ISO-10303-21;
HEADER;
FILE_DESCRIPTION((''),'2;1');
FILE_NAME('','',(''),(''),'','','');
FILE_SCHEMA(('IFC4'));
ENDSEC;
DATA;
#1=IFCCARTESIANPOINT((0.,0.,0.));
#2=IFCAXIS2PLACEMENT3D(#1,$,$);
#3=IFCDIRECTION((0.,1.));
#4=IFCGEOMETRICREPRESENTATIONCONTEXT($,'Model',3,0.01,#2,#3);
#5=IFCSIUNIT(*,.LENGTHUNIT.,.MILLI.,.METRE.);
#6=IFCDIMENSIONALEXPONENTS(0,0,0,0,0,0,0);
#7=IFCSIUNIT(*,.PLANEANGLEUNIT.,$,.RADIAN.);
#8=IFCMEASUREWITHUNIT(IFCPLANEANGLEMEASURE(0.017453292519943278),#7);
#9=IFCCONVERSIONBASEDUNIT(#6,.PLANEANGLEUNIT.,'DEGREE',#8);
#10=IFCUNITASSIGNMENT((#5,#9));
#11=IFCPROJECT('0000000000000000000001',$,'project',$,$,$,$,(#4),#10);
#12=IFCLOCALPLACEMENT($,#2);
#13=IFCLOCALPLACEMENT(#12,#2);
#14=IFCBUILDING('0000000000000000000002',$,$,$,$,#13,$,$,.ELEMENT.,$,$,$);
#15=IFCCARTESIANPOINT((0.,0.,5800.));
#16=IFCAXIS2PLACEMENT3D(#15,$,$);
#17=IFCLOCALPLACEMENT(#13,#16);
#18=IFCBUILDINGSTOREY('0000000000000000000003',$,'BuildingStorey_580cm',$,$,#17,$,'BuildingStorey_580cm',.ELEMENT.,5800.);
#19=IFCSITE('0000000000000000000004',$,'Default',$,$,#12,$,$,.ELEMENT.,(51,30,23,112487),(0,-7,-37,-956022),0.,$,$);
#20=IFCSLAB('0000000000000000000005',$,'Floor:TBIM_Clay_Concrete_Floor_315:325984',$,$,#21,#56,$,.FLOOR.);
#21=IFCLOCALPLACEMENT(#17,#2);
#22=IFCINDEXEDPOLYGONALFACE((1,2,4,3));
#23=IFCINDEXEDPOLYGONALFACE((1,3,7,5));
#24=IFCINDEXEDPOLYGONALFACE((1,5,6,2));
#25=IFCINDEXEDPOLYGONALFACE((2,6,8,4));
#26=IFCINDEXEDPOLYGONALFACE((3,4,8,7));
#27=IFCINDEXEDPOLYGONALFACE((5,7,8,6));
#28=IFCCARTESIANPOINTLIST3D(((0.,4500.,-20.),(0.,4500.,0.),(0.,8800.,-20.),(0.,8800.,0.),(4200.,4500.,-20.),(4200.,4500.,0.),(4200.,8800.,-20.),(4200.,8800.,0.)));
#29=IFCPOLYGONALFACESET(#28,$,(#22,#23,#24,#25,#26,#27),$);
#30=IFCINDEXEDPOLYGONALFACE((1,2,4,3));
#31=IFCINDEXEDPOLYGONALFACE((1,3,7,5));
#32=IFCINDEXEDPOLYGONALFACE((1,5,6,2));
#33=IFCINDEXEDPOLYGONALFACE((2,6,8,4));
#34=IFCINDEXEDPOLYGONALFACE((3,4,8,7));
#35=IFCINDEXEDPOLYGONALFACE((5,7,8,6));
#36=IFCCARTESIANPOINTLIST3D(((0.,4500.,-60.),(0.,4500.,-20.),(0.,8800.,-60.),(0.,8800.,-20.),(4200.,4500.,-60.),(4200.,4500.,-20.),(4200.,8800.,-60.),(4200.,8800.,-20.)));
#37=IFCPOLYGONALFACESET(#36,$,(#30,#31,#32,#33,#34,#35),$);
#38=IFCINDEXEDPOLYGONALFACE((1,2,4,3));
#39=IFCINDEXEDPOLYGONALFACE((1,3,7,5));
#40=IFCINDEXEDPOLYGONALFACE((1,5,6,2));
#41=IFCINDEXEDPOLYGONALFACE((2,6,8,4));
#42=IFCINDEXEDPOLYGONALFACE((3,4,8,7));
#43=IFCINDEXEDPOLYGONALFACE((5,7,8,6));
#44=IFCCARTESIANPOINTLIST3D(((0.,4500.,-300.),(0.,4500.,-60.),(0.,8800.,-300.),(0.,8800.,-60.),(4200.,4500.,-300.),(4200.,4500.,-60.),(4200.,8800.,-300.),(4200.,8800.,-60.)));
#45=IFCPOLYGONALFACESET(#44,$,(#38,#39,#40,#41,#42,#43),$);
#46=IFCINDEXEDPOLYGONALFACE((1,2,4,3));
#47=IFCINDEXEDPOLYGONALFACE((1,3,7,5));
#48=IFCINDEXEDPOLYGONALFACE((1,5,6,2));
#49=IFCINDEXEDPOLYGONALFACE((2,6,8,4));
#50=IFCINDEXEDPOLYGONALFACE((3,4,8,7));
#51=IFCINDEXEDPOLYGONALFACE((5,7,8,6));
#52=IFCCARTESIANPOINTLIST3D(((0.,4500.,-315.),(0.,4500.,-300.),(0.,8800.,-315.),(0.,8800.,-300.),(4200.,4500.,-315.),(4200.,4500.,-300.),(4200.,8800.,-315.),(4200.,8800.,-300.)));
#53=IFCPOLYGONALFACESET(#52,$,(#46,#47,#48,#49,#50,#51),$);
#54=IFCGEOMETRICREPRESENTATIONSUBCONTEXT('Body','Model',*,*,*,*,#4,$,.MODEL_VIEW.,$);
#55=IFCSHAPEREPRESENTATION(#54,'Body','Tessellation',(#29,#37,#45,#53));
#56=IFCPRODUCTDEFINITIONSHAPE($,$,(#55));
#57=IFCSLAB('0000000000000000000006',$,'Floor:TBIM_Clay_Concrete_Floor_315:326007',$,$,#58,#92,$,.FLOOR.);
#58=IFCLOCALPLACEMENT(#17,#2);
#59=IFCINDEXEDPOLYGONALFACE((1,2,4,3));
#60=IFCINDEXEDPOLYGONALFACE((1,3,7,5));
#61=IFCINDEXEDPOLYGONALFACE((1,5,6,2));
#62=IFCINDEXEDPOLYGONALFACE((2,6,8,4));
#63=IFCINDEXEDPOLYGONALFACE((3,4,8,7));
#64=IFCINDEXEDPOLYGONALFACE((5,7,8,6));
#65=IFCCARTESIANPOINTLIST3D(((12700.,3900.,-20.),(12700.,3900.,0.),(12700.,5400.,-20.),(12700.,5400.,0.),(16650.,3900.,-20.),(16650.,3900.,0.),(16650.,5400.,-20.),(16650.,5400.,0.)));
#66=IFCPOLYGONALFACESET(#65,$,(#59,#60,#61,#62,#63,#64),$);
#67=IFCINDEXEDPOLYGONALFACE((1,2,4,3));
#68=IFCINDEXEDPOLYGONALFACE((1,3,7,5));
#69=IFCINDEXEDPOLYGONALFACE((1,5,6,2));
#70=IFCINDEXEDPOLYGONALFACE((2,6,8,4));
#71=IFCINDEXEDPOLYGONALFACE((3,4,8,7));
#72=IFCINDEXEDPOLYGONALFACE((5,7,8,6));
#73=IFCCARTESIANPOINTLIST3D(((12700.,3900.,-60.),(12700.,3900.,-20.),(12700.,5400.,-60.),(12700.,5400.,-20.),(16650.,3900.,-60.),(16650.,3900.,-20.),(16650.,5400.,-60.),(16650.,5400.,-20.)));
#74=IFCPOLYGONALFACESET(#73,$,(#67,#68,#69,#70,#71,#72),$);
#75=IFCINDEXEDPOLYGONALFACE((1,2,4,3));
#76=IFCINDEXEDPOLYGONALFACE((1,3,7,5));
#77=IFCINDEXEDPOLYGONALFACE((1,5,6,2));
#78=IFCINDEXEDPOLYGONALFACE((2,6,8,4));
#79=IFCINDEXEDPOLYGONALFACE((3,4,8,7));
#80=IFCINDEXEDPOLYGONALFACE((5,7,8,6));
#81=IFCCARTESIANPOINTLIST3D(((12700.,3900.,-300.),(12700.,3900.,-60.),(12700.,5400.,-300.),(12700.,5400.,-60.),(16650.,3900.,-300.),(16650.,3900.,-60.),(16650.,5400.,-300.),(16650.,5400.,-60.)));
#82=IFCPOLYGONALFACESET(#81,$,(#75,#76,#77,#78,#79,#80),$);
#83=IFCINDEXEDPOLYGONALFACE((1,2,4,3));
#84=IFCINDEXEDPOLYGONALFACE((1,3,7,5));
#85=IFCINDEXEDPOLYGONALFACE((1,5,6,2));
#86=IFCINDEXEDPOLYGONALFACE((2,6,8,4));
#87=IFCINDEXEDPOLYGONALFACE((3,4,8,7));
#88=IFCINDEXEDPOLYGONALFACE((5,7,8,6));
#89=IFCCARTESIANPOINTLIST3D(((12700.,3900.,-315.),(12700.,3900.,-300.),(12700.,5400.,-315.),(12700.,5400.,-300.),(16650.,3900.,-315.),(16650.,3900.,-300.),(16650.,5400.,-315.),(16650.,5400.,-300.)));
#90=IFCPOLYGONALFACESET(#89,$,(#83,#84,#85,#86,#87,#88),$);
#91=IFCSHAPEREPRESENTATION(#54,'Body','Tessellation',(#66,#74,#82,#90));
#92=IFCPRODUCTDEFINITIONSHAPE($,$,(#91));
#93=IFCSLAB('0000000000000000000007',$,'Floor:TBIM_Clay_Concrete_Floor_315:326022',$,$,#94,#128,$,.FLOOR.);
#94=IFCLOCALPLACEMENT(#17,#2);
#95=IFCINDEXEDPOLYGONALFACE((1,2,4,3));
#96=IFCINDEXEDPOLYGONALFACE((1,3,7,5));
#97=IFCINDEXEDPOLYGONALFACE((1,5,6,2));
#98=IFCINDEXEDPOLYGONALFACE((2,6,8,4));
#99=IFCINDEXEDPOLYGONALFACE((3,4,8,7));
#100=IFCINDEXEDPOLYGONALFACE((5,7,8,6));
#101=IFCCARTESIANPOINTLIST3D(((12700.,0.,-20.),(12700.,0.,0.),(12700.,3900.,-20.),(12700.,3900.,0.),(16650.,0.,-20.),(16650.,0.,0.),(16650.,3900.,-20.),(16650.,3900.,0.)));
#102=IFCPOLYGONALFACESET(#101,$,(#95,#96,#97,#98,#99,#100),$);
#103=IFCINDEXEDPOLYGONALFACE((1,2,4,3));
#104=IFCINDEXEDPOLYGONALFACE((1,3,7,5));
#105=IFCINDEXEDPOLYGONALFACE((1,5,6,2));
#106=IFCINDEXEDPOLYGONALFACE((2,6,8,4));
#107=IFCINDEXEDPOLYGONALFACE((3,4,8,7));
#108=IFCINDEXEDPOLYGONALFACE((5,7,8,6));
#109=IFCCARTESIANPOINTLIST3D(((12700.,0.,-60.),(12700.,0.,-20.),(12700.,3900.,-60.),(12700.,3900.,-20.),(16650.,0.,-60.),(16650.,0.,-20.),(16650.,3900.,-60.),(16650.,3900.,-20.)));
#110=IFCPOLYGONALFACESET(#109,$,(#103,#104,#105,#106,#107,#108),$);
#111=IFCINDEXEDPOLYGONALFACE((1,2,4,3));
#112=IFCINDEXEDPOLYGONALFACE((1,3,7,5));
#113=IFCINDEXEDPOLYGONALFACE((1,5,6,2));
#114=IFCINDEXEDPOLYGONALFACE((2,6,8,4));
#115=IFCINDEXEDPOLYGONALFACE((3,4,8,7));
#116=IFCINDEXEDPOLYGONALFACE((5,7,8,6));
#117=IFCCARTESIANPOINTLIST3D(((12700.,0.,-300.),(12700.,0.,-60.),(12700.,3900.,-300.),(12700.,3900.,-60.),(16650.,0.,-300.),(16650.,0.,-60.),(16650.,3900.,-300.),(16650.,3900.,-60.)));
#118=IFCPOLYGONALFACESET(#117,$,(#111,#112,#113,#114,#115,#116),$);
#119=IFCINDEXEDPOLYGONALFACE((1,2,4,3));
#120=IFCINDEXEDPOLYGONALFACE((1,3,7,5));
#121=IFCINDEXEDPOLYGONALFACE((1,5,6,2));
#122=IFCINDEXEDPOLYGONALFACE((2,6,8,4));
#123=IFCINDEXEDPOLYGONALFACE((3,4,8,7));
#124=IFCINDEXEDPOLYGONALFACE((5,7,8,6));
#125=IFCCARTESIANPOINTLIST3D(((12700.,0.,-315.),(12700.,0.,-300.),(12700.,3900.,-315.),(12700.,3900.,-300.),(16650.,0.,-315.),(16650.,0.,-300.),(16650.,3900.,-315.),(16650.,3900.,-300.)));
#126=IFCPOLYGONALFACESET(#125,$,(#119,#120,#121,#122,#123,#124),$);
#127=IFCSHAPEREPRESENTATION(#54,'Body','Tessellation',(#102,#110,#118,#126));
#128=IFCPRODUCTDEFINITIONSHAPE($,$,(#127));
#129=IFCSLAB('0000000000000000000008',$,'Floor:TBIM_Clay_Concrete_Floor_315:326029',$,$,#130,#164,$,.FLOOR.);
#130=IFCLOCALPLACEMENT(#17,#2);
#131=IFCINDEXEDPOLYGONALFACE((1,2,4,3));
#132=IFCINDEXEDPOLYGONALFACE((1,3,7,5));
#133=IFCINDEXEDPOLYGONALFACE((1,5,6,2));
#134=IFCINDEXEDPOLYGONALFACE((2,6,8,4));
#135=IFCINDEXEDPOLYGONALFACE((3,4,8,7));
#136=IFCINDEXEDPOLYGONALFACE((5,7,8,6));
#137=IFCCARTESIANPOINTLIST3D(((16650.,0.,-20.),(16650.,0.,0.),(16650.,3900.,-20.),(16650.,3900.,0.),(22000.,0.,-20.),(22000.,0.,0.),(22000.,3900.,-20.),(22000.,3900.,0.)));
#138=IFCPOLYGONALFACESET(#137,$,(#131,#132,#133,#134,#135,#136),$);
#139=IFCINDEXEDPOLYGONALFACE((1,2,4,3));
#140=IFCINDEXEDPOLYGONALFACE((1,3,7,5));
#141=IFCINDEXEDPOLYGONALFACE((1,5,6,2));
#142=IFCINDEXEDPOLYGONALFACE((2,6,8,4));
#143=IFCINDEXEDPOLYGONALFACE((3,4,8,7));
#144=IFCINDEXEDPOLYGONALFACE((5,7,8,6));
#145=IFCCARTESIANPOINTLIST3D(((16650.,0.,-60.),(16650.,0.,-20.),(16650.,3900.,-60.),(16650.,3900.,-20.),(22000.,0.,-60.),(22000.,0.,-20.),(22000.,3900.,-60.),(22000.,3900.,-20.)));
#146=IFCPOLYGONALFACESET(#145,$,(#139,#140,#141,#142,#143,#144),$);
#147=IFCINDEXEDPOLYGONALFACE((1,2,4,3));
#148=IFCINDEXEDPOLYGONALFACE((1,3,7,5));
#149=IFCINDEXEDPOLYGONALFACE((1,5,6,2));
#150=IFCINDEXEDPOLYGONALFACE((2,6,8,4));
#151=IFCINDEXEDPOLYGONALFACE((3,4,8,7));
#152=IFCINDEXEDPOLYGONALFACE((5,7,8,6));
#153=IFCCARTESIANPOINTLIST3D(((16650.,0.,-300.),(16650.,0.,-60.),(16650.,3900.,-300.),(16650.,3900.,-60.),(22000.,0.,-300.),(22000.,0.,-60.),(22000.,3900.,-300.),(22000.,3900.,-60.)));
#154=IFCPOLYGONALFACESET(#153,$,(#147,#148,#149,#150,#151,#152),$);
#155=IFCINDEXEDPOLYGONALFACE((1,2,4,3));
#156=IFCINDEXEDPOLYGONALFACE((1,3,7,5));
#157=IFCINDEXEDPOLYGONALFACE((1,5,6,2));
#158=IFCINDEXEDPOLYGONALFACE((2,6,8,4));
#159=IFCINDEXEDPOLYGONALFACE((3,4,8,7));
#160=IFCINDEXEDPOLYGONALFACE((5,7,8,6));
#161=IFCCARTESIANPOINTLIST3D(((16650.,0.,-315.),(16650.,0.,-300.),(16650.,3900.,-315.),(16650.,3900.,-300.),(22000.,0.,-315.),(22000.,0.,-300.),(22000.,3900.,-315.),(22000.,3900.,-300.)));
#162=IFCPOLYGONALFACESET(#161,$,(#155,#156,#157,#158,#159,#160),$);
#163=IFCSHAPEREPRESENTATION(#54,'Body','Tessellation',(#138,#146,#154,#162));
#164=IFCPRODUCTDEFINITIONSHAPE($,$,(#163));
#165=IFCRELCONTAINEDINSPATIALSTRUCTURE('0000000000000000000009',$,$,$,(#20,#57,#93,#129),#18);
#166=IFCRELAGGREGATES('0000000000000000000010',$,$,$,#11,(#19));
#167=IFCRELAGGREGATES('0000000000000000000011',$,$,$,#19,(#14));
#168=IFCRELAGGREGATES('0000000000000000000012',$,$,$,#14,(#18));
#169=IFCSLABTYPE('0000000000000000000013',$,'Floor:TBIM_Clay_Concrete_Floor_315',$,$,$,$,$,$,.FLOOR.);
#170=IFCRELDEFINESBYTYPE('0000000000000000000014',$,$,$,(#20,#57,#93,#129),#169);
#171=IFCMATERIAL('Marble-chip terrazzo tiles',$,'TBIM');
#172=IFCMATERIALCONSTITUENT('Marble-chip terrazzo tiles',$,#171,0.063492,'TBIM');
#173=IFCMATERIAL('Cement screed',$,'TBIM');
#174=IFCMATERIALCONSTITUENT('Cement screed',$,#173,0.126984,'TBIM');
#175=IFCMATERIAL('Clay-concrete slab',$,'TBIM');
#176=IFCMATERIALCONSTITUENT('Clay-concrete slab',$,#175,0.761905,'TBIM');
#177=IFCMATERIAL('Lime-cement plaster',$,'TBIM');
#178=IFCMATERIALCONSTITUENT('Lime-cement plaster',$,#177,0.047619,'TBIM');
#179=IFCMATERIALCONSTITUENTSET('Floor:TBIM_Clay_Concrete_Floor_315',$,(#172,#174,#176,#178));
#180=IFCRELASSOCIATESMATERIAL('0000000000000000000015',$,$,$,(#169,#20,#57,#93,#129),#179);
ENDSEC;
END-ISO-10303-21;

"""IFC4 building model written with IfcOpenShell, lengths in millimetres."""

from ifc_helpers import new_model, entity, si_unit, converted_unit, direction, frame, origin, place, context, subcontext, project, spatial, indexed_curve, outline, extrude, material, constituent, constituent_set, type_object, element, save


model = new_model("IFC4")

# Units and contexts
model_context = context("Model", 3, precision=0.01, world=origin(), true_north=direction((0.0, 1.0)))
body_context = subcontext(model_context, "Body", "Model", "MODEL_VIEW")
ifc_project = project(units=[si_unit("LENGTHUNIT", "METRE", prefix="MILLI"), converted_unit("PLANEANGLEUNIT", "DEGREE", entity("IfcPlaneAngleMeasure", 0.017453292519943278), si_unit("PLANEANGLEUNIT", "RADIAN"), dimensions=[0, 0, 0, 0, 0, 0, 0])], contexts=[model_context])

# Site, building, storey
site_placement = place(None, origin())
site = spatial("IfcSite", under=ifc_project, at=site_placement, Name="Default", CompositionType="ELEMENT", RefLatitude=(51, 30, 23, 112487), RefLongitude=(0, -7, -37, -956022), RefElevation=0.0)
building_placement = place(site_placement, origin())
building = spatial("IfcBuilding", under=site, at=building_placement, CompositionType="ELEMENT")
storey_placement = place(building_placement, frame((0.0, 0.0, 5800.0)))
storey = spatial("IfcBuildingStorey", under=building, at=storey_placement, Name="BuildingStorey_580cm", LongName="BuildingStorey_580cm", CompositionType="ELEMENT", Elevation=5800.0)

# Slabs
ifc_material_1 = material(Name="Marble-chip terrazzo tiles", Category="TBIM")
ifc_constituent_1 = constituent(ifc_material_1, Name="Marble-chip terrazzo tiles", Category="TBIM", fraction=0.063492)
ifc_material_2 = material(Name="Cement screed", Category="TBIM")
ifc_constituent_2 = constituent(ifc_material_2, Name="Cement screed", Category="TBIM", fraction=0.126984)
ifc_material_3 = material(Name="Clay-concrete slab", Category="TBIM")
ifc_constituent_3 = constituent(ifc_material_3, Name="Clay-concrete slab", Category="TBIM", fraction=0.761905)
ifc_material_4 = material(Name="Lime-cement plaster", Category="TBIM")
ifc_constituent_4 = constituent(ifc_material_4, Name="Lime-cement plaster", Category="TBIM", fraction=0.047619)
ifc_constituent_set_1 = constituent_set(constituents=[ifc_constituent_1, ifc_constituent_2, ifc_constituent_3, ifc_constituent_4], Name="Floor:TBIM_Clay_Concrete_Floor_315")
slab_type = type_object("IfcSlabType", Name="Floor:TBIM_Clay_Concrete_Floor_315", PredefinedType="FLOOR", material=ifc_constituent_set_1)
slab_1_placement = place(storey_placement, origin())
element("IfcSlab", 1, at=slab_1_placement, inside=storey, type_object=slab_type, material=ifc_constituent_set_1, Name="Floor:TBIM_Clay_Concrete_Floor_315:325984", PredefinedType="FLOOR", context=body_context, shape_type="SweptSolid", body=[
    extrude(outline(indexed_curve([(-2100.0, -2150.0), (2100.0, -2150.0), (2100.0, 2150.0), (-2100.0, 2150.0), (-2100.0, -2150.0)], self_intersect=False)), frame((2100.0, 6650.0, -20.0), z_axis=(0.0, 0.0, 1.0), x_axis=(-1.0, 0.0, 0.0)), (0.0, 0.0, 1.0), 20.0),
    extrude(outline(indexed_curve([(-2100.0, -2150.0), (2100.0, -2150.0), (2100.0, 2150.0), (-2100.0, 2150.0), (-2100.0, -2150.0)], self_intersect=False)), frame((2100.0, 6650.0, -60.0), z_axis=(0.0, 0.0, 1.0), x_axis=(-1.0, 0.0, 0.0)), (0.0, 0.0, 1.0), 40.0),
    extrude(outline(indexed_curve([(-2100.0, -2150.0), (2100.0, -2150.0), (2100.0, 2150.0), (-2100.0, 2150.0), (-2100.0, -2150.0)], self_intersect=False)), frame((2100.0, 6650.0, -300.0), z_axis=(0.0, 0.0, 1.0), x_axis=(-1.0, 0.0, 0.0)), (0.0, 0.0, 1.0), 240.0),
    extrude(outline(indexed_curve([(-2100.0, -2150.0), (2100.0, -2150.0), (2100.0, 2150.0), (-2100.0, 2150.0), (-2100.0, -2150.0)], self_intersect=False)), frame((2100.0, 6650.0, -315.0), z_axis=(0.0, 0.0, 1.0), x_axis=(-1.0, 0.0, 0.0)), (0.0, 0.0, 1.0), 15.0),
])
slab_2_placement = place(storey_placement, origin())
element("IfcSlab", 2, at=slab_2_placement, inside=storey, type_object=slab_type, material=ifc_constituent_set_1, Name="Floor:TBIM_Clay_Concrete_Floor_315:326007", PredefinedType="FLOOR", context=body_context, shape_type="SweptSolid", body=[
    extrude(outline(indexed_curve([(-750.0, -1975.0), (750.0, -1975.0), (750.0, 1975.0), (-750.0, 1975.0), (-750.0, -1975.0)], self_intersect=False)), frame((14675.0, 4650.0, -20.0), z_axis=(0.0, 0.0, 1.0), x_axis=(0.0, 1.0, 0.0)), (0.0, 0.0, 1.0), 20.0),
    extrude(outline(indexed_curve([(-750.0, -1975.0), (750.0, -1975.0), (750.0, 1975.0), (-750.0, 1975.0), (-750.0, -1975.0)], self_intersect=False)), frame((14675.0, 4650.0, -60.0), z_axis=(0.0, 0.0, 1.0), x_axis=(0.0, 1.0, 0.0)), (0.0, 0.0, 1.0), 40.0),
    extrude(outline(indexed_curve([(-750.0, -1975.0), (750.0, -1975.0), (750.0, 1975.0), (-750.0, 1975.0), (-750.0, -1975.0)], self_intersect=False)), frame((14675.0, 4650.0, -300.0), z_axis=(0.0, 0.0, 1.0), x_axis=(0.0, 1.0, 0.0)), (0.0, 0.0, 1.0), 240.0),
    extrude(outline(indexed_curve([(-750.0, -1975.0), (750.0, -1975.0), (750.0, 1975.0), (-750.0, 1975.0), (-750.0, -1975.0)], self_intersect=False)), frame((14675.0, 4650.0, -315.0), z_axis=(0.0, 0.0, 1.0), x_axis=(0.0, 1.0, 0.0)), (0.0, 0.0, 1.0), 15.0),
])
slab_3_placement = place(storey_placement, origin())
element("IfcSlab", 3, at=slab_3_placement, inside=storey, type_object=slab_type, material=ifc_constituent_set_1, Name="Floor:TBIM_Clay_Concrete_Floor_315:326022", PredefinedType="FLOOR", context=body_context, shape_type="SweptSolid", body=[
    extrude(outline(indexed_curve([(-1975.0, -1950.0), (1975.0, -1950.0), (1975.0, 1950.0), (-1975.0, 1950.0), (-1975.0, -1950.0)], self_intersect=False)), frame((14675.0, 1950.0, -20.0), z_axis=(0.0, 0.0, 1.0), x_axis=(-1.0, 0.0, 0.0)), (0.0, 0.0, 1.0), 20.0),
    extrude(outline(indexed_curve([(-1975.0, -1950.0), (1975.0, -1950.0), (1975.0, 1950.0), (-1975.0, 1950.0), (-1975.0, -1950.0)], self_intersect=False)), frame((14675.0, 1950.0, -60.0), z_axis=(0.0, 0.0, 1.0), x_axis=(-1.0, 0.0, 0.0)), (0.0, 0.0, 1.0), 40.0),
    extrude(outline(indexed_curve([(-1975.0, -1950.0), (1975.0, -1950.0), (1975.0, 1950.0), (-1975.0, 1950.0), (-1975.0, -1950.0)], self_intersect=False)), frame((14675.0, 1950.0, -300.0), z_axis=(0.0, 0.0, 1.0), x_axis=(-1.0, 0.0, 0.0)), (0.0, 0.0, 1.0), 240.0),
    extrude(outline(indexed_curve([(-1975.0, -1950.0), (1975.0, -1950.0), (1975.0, 1950.0), (-1975.0, 1950.0), (-1975.0, -1950.0)], self_intersect=False)), frame((14675.0, 1950.0, -315.0), z_axis=(0.0, 0.0, 1.0), x_axis=(-1.0, 0.0, 0.0)), (0.0, 0.0, 1.0), 15.0),
])
slab_4_placement = place(storey_placement, origin())
element("IfcSlab", 4, at=slab_4_placement, inside=storey, type_object=slab_type, material=ifc_constituent_set_1, Name="Floor:TBIM_Clay_Concrete_Floor_315:326029", PredefinedType="FLOOR", context=body_context, shape_type="SweptSolid", body=[
    extrude(outline(indexed_curve([(-2675.0, -1950.0), (2675.0, -1950.0), (2675.0, 1950.0), (-2675.0, 1950.0), (-2675.0, -1950.0)], self_intersect=False)), frame((19325.0, 1950.0, -20.0), z_axis=(0.0, 0.0, 1.0), x_axis=(-1.0, 0.0, 0.0)), (0.0, 0.0, 1.0), 20.0),
    extrude(outline(indexed_curve([(-2675.0, -1950.0), (2675.0, -1950.0), (2675.0, 1950.0), (-2675.0, 1950.0), (-2675.0, -1950.0)], self_intersect=False)), frame((19325.0, 1950.0, -60.0), z_axis=(0.0, 0.0, 1.0), x_axis=(-1.0, 0.0, 0.0)), (0.0, 0.0, 1.0), 40.0),
    extrude(outline(indexed_curve([(-2675.0, -1950.0), (2675.0, -1950.0), (2675.0, 1950.0), (-2675.0, 1950.0), (-2675.0, -1950.0)], self_intersect=False)), frame((19325.0, 1950.0, -300.0), z_axis=(0.0, 0.0, 1.0), x_axis=(-1.0, 0.0, 0.0)), (0.0, 0.0, 1.0), 240.0),
    extrude(outline(indexed_curve([(-2675.0, -1950.0), (2675.0, -1950.0), (2675.0, 1950.0), (-2675.0, 1950.0), (-2675.0, -1950.0)], self_intersect=False)), frame((19325.0, 1950.0, -315.0), z_axis=(0.0, 0.0, 1.0), x_axis=(-1.0, 0.0, 0.0)), (0.0, 0.0, 1.0), 15.0),
])

save(model, "model.ifc")
